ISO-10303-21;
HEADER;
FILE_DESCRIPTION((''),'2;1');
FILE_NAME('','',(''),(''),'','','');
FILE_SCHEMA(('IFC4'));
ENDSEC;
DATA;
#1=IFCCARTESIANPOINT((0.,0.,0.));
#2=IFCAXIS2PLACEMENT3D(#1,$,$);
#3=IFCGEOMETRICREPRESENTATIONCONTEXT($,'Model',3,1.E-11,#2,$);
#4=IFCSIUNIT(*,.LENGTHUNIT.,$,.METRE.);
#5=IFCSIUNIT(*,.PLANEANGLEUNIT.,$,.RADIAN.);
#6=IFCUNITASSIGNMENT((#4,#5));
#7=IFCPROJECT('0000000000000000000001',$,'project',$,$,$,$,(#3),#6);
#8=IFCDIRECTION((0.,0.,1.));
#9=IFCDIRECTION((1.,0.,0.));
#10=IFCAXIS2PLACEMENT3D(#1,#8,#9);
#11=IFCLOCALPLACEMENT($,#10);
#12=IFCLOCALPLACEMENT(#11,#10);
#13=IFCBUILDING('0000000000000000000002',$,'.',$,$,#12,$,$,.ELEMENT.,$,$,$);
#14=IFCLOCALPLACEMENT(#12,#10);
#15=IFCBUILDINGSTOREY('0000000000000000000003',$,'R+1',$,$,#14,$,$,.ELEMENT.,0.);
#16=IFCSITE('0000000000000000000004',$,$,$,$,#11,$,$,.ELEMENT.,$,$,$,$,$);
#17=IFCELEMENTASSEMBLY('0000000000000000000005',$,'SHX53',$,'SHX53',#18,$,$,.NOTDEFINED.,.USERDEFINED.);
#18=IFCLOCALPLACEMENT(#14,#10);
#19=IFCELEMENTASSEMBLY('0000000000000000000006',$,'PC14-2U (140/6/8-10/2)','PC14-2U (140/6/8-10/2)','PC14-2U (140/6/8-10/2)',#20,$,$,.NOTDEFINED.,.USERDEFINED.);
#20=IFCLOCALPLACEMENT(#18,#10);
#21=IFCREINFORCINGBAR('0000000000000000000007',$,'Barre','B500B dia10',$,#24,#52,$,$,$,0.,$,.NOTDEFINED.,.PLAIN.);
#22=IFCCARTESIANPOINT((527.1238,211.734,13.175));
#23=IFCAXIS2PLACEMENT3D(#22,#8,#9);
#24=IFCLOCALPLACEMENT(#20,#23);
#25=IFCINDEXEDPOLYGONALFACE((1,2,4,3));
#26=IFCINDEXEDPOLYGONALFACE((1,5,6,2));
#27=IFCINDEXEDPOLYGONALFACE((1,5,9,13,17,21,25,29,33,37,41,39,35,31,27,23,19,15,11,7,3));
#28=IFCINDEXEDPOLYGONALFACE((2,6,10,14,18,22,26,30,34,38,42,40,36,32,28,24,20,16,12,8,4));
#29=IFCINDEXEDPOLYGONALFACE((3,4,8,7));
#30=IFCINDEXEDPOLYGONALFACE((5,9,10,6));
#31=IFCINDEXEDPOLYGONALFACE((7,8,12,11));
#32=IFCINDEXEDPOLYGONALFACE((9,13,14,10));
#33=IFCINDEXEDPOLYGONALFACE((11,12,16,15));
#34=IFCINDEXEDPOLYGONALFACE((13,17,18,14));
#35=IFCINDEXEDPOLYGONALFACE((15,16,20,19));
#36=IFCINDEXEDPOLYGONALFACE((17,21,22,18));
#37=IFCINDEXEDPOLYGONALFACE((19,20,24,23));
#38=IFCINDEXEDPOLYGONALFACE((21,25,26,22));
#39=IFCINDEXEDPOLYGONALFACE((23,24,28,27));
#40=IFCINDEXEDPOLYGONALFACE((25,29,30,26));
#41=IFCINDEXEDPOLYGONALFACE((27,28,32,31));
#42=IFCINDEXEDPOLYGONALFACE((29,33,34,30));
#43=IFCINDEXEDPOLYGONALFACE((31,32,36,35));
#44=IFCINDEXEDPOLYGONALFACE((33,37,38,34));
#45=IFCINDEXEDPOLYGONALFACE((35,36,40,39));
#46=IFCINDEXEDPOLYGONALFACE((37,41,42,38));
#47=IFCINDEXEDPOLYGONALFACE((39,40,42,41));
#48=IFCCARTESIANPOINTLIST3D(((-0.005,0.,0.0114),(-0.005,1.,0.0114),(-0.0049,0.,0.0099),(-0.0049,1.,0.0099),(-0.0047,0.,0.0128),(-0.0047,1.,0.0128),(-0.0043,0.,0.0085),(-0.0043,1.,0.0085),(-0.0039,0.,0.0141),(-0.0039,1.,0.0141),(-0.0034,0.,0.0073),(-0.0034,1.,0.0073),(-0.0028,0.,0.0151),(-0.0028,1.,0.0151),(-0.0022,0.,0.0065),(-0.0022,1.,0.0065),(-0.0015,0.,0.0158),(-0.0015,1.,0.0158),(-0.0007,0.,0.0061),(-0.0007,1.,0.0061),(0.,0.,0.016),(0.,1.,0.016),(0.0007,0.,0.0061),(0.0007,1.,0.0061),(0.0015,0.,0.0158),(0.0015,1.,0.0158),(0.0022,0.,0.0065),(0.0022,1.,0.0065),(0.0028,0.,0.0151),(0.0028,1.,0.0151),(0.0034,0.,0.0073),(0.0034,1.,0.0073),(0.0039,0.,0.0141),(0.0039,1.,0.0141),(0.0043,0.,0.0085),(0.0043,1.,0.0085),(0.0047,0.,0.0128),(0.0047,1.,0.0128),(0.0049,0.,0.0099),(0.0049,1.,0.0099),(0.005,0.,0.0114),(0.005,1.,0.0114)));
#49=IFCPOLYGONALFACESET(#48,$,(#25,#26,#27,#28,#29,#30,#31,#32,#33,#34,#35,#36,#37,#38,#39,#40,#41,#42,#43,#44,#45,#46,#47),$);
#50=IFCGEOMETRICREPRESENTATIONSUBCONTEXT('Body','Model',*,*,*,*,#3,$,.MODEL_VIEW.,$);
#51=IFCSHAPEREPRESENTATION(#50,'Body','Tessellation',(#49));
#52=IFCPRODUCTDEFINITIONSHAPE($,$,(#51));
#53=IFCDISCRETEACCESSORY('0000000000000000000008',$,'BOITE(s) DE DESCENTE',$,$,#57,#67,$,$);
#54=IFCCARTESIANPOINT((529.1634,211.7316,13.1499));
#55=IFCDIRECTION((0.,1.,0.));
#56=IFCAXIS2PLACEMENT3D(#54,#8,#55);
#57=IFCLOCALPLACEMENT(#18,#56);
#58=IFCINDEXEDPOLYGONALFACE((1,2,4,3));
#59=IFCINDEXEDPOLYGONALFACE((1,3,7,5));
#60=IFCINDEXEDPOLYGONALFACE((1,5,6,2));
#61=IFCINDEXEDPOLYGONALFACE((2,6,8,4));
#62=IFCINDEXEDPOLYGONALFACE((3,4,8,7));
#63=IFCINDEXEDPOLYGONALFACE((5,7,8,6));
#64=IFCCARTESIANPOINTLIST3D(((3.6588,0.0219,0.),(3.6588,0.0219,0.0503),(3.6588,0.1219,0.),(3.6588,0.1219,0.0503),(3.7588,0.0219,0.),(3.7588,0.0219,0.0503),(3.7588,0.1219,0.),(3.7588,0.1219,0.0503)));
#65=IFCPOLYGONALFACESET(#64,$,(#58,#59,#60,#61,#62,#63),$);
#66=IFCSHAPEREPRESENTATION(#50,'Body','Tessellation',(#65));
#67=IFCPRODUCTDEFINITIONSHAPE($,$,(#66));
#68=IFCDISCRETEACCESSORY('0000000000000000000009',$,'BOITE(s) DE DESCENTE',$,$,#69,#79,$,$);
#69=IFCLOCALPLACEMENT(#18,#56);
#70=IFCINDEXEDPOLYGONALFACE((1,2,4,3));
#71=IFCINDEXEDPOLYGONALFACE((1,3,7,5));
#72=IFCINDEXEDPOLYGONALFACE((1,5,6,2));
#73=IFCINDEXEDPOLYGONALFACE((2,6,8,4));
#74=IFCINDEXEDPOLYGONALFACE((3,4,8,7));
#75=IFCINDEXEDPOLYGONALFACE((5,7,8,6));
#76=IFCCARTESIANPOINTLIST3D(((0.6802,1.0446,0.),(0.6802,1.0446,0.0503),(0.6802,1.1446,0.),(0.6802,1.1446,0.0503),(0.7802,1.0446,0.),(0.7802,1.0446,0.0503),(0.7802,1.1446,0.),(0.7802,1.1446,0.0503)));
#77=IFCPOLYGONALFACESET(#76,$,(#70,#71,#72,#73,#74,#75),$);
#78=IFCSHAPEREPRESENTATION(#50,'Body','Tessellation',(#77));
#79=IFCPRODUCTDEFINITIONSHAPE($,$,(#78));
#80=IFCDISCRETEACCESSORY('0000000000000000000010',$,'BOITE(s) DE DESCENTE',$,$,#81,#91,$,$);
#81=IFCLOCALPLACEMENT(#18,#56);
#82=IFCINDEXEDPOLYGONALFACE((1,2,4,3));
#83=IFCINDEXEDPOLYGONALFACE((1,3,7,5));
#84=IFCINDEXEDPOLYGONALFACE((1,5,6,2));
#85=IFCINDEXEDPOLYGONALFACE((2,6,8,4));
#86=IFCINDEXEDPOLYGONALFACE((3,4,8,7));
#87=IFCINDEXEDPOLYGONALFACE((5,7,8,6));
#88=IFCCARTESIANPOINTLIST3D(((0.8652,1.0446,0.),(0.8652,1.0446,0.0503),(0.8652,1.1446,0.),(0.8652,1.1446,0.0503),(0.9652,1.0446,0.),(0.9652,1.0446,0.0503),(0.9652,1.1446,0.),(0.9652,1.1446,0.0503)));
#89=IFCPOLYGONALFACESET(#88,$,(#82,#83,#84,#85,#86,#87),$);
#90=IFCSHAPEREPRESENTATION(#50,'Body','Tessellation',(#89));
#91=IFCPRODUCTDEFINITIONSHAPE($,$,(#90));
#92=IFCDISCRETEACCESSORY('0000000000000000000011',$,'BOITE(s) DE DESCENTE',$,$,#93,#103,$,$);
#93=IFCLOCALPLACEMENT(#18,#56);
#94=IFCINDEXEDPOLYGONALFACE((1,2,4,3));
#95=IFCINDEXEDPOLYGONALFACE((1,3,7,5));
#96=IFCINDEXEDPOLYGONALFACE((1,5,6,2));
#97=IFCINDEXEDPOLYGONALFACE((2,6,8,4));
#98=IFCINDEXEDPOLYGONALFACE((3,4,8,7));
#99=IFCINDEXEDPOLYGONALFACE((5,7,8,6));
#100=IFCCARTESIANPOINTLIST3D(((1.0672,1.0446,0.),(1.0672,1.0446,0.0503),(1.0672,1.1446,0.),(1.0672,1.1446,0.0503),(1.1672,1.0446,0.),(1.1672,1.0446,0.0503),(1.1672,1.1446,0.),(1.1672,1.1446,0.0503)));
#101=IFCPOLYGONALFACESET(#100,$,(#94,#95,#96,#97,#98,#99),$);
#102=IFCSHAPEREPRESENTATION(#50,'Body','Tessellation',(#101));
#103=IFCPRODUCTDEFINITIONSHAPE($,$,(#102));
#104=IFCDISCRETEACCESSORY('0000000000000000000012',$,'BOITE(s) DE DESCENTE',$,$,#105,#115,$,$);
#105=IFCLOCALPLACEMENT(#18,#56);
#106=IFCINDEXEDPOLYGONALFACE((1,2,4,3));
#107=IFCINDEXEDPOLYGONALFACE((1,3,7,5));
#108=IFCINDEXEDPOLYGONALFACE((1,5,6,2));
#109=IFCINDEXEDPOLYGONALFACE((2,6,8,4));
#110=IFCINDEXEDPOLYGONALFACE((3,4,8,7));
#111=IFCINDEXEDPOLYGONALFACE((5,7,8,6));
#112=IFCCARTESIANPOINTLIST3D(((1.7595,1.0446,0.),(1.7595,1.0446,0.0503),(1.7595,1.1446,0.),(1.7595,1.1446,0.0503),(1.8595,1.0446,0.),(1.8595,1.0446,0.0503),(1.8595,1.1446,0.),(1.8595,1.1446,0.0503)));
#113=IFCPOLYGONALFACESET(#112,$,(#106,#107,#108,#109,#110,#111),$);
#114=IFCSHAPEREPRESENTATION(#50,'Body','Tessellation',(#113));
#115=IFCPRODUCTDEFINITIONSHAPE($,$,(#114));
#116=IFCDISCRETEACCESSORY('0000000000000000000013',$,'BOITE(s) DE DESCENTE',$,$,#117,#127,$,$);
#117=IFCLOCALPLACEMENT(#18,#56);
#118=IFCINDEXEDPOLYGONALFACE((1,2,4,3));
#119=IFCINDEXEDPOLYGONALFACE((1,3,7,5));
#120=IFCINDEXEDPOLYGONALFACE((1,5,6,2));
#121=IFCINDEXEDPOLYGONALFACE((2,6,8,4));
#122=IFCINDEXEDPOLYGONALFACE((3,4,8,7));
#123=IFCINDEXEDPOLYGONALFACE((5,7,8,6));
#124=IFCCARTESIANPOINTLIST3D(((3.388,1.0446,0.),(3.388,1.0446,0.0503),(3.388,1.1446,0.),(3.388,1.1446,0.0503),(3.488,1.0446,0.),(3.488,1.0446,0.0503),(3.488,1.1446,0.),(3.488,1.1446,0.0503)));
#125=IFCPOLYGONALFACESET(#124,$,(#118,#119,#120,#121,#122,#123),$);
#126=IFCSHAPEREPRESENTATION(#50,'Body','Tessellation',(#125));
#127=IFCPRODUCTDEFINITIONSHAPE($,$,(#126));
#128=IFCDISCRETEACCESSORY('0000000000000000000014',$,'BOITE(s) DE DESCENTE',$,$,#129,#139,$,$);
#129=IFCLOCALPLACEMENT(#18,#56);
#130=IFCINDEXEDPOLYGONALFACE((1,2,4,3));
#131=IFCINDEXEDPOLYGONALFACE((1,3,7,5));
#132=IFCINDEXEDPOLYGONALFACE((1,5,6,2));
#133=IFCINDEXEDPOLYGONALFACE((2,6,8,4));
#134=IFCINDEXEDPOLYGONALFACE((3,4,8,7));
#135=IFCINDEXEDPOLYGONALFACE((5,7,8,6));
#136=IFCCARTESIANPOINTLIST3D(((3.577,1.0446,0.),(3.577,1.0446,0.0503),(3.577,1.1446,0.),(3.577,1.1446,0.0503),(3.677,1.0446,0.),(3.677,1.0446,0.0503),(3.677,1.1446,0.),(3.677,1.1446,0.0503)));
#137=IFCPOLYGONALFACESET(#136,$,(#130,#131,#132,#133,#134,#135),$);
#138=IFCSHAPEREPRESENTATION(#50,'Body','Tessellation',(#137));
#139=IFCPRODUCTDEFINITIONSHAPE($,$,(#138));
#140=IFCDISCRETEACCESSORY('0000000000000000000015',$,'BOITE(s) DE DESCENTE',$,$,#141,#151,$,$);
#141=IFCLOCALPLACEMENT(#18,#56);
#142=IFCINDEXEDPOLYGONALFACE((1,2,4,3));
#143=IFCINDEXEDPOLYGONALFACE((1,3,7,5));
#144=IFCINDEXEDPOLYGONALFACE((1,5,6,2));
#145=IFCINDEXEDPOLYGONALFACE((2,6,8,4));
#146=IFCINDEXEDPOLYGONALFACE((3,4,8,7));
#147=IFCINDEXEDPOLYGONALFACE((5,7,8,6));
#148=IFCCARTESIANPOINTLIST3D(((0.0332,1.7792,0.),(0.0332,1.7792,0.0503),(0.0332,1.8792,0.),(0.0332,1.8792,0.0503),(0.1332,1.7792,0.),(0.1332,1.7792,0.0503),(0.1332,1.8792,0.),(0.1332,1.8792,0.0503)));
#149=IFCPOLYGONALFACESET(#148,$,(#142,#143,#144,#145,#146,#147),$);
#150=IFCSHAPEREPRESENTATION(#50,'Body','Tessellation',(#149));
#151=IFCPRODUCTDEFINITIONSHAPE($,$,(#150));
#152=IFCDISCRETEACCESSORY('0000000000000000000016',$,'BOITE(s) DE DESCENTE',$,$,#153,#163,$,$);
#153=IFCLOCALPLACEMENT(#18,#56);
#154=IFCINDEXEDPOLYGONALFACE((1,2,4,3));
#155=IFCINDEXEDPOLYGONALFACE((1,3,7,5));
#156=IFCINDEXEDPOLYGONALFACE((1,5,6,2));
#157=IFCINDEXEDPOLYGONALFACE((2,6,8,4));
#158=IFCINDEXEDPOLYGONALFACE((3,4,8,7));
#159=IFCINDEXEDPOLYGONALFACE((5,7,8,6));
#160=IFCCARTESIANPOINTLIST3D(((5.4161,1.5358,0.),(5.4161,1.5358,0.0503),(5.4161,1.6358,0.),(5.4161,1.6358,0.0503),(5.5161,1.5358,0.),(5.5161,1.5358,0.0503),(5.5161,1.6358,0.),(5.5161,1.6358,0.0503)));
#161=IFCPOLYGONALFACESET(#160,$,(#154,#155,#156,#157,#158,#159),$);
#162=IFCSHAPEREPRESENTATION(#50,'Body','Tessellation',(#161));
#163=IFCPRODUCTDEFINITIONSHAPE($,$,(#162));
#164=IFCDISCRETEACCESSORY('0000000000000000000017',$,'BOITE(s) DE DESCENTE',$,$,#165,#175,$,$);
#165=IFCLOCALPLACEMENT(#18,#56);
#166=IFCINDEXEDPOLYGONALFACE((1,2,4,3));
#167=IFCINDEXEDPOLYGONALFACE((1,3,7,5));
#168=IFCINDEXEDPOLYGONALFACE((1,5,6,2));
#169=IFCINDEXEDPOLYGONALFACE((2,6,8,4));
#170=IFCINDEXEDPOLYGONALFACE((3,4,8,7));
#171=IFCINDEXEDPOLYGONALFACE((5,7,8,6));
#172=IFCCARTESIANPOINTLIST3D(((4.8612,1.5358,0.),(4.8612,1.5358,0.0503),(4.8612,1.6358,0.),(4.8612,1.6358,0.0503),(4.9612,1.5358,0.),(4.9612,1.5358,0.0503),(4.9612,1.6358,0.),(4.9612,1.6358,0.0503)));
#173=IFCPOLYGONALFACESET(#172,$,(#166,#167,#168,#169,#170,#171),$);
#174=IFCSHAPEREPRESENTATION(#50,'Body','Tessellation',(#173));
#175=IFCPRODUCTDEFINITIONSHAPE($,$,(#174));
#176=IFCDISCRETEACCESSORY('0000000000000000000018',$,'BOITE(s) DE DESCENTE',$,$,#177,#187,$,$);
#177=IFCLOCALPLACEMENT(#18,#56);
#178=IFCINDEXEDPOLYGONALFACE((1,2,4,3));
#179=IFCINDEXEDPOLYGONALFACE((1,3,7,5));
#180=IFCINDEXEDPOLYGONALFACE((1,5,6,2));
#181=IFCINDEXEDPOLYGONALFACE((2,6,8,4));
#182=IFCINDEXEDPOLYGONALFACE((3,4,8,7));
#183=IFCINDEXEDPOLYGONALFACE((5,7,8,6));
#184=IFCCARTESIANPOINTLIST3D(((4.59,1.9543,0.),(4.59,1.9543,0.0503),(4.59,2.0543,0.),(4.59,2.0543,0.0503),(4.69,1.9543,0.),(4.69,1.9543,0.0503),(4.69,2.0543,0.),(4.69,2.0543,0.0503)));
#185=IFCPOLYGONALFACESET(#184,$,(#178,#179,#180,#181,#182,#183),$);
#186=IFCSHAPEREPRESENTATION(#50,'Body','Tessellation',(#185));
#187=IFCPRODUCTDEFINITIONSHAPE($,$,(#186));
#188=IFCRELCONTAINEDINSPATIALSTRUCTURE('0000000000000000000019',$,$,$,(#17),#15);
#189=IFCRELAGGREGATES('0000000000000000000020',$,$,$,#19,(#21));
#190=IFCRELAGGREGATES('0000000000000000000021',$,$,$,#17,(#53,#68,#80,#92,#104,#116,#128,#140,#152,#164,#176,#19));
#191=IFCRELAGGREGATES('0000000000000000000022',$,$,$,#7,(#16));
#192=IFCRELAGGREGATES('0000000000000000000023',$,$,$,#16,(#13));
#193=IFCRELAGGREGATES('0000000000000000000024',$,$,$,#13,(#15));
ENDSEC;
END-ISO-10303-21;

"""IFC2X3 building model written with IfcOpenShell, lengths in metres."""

from ifc_helpers import new_model, entity, si_unit, frame, origin, origin_with_axes, place, context, subcontext, project, spatial, polyline, outline, extrude, source, transform, mapped, element, aggregate, save


model = new_model("IFC2X3")

# Units and contexts
model_context = context("Model", 3, precision=1e-11, world=origin())
body_context = subcontext(model_context, "Body", "Model", "MODEL_VIEW")
ifc_project = project(units=[si_unit("LENGTHUNIT", "METRE"), si_unit("PLANEANGLEUNIT", "RADIAN")], contexts=[model_context])

# Site, building, storey
site_placement = place(None, origin_with_axes())
site = spatial("IfcSite", under=ifc_project, at=site_placement, CompositionType="ELEMENT")
building_placement = place(site_placement, origin_with_axes())
building = spatial("IfcBuilding", under=site, at=building_placement, Name=".", CompositionType="ELEMENT")
storey_placement = place(building_placement, origin_with_axes())
storey = spatial("IfcBuildingStorey", under=building, at=storey_placement, Name="R+1", CompositionType="ELEMENT", Elevation=0.0)

# Element assemblies, reinforcing bar, discrete accessories
assembly_1_placement = place(storey_placement, origin_with_axes())
assembly_1 = element("IfcElementAssembly", 1, at=assembly_1_placement, inside=storey, Name="SHX53", ObjectType="SHX53", AssemblyPlace="NOTDEFINED", PredefinedType="USERDEFINED")
assembly_2_placement = place(assembly_1_placement, origin_with_axes())
assembly_2 = element("IfcElementAssembly", 2, at=assembly_2_placement, Name="PC14-2U (140/6/8-10/2)", Description="PC14-2U (140/6/8-10/2)", ObjectType="PC14-2U (140/6/8-10/2)", AssemblyPlace="NOTDEFINED", PredefinedType="USERDEFINED")
shared_shape_1 = source(origin_with_axes(), body_context, "Body", "AdvancedSweptSolid", [
    entity("IfcSweptDiskSolid", entity("IfcPolyline", [entity("IfcCartesianPoint", [0.0, 0.0, 0.011]), entity("IfcCartesianPoint", [0.0, 1.0, 0.011])]), 0.005, None, 0.0, 1.0),
])
reinforcing_bar_1_placement = place(assembly_2_placement, frame((527.1238, 211.734, 13.175), z_axis=(0.0, 0.0, 1.0), x_axis=(1.0, 0.0, 0.0)))
reinforcing_bar_1 = element("IfcReinforcingBar", 3, at=reinforcing_bar_1_placement, Name="Barre", Description="B500B dia10", BarRole="NOTDEFINED", BarSurface="PLAIN", CrossSectionArea=0.0, context=body_context, shape_type="MappedRepresentation", body=[
    mapped(shared_shape_1, transform((0.0, 0.0, 0.0), scale=1.0)),
])
aggregate(assembly_2, [reinforcing_bar_1])
discrete_accessory_1_placement = place(assembly_1_placement, frame((529.1634, 211.7316, 13.1499), z_axis=(0.0, 0.0, 1.0), x_axis=(0.0, 1.0, 0.0)))
discrete_accessory_1 = element("IfcDiscreteAccessory", 4, at=discrete_accessory_1_placement, Name="BOITE(s) DE DESCENTE", context=body_context, shape_type="SweptSolid", body=[
    extrude(outline(polyline([(0.0219, -3.6588), (0.0219, -3.7588), (0.1219, -3.7588), (0.1219, -3.6588), (0.0219, -3.6588)])), frame((0.0, 0.0, 0.0), z_axis=(0.0, 0.0, 1.0), x_axis=(0.0, 1.0, 0.0)), (0.0, 0.0, 1.0), 0.0503),
])
discrete_accessory_2_placement = place(assembly_1_placement, frame((529.1634, 211.7316, 13.1499), z_axis=(0.0, 0.0, 1.0), x_axis=(0.0, 1.0, 0.0)))
discrete_accessory_2 = element("IfcDiscreteAccessory", 5, at=discrete_accessory_2_placement, Name="BOITE(s) DE DESCENTE", context=body_context, shape_type="SweptSolid", body=[
    extrude(outline(polyline([(1.0446, -0.6802), (1.0446, -0.7802), (1.1446, -0.7802), (1.1446, -0.6802), (1.0446, -0.6802)])), frame((0.0, 0.0, 0.0), z_axis=(0.0, 0.0, 1.0), x_axis=(0.0, 1.0, 0.0)), (0.0, 0.0, 1.0), 0.0503),
])
discrete_accessory_3_placement = place(assembly_1_placement, frame((529.1634, 211.7316, 13.1499), z_axis=(0.0, 0.0, 1.0), x_axis=(0.0, 1.0, 0.0)))
discrete_accessory_3 = element("IfcDiscreteAccessory", 6, at=discrete_accessory_3_placement, Name="BOITE(s) DE DESCENTE", context=body_context, shape_type="SweptSolid", body=[
    extrude(outline(polyline([(1.0446, -0.8652), (1.0446, -0.9652), (1.1446, -0.9652), (1.1446, -0.8652), (1.0446, -0.8652)])), frame((0.0, 0.0, 0.0), z_axis=(0.0, 0.0, 1.0), x_axis=(0.0, 1.0, 0.0)), (0.0, 0.0, 1.0), 0.0503),
])
discrete_accessory_4_placement = place(assembly_1_placement, frame((529.1634, 211.7316, 13.1499), z_axis=(0.0, 0.0, 1.0), x_axis=(0.0, 1.0, 0.0)))
discrete_accessory_4 = element("IfcDiscreteAccessory", 7, at=discrete_accessory_4_placement, Name="BOITE(s) DE DESCENTE", context=body_context, shape_type="SweptSolid", body=[
    extrude(outline(polyline([(1.0446, -1.0672), (1.0446, -1.1672), (1.1446, -1.1672), (1.1446, -1.0672), (1.0446, -1.0672)])), frame((0.0, 0.0, 0.0), z_axis=(0.0, 0.0, 1.0), x_axis=(0.0, 1.0, 0.0)), (0.0, 0.0, 1.0), 0.0503),
])
discrete_accessory_5_placement = place(assembly_1_placement, frame((529.1634, 211.7316, 13.1499), z_axis=(0.0, 0.0, 1.0), x_axis=(0.0, 1.0, 0.0)))
discrete_accessory_5 = element("IfcDiscreteAccessory", 8, at=discrete_accessory_5_placement, Name="BOITE(s) DE DESCENTE", context=body_context, shape_type="SweptSolid", body=[
    extrude(outline(polyline([(1.0446, -1.7595), (1.0446, -1.8595), (1.1446, -1.8595), (1.1446, -1.7595), (1.0446, -1.7595)])), frame((0.0, 0.0, 0.0), z_axis=(0.0, 0.0, 1.0), x_axis=(0.0, 1.0, 0.0)), (0.0, 0.0, 1.0), 0.0503),
])
discrete_accessory_6_placement = place(assembly_1_placement, frame((529.1634, 211.7316, 13.1499), z_axis=(0.0, 0.0, 1.0), x_axis=(0.0, 1.0, 0.0)))
discrete_accessory_6 = element("IfcDiscreteAccessory", 9, at=discrete_accessory_6_placement, Name="BOITE(s) DE DESCENTE", context=body_context, shape_type="SweptSolid", body=[
    extrude(outline(polyline([(1.0446, -3.388), (1.0446, -3.488), (1.1446, -3.488), (1.1446, -3.388), (1.0446, -3.388)])), frame((0.0, 0.0, 0.0), z_axis=(0.0, 0.0, 1.0), x_axis=(0.0, 1.0, 0.0)), (0.0, 0.0, 1.0), 0.0503),
])
discrete_accessory_7_placement = place(assembly_1_placement, frame((529.1634, 211.7316, 13.1499), z_axis=(0.0, 0.0, 1.0), x_axis=(0.0, 1.0, 0.0)))
discrete_accessory_7 = element("IfcDiscreteAccessory", 10, at=discrete_accessory_7_placement, Name="BOITE(s) DE DESCENTE", context=body_context, shape_type="SweptSolid", body=[
    extrude(outline(polyline([(1.0446, -3.577), (1.0446, -3.677), (1.1446, -3.677), (1.1446, -3.577), (1.0446, -3.577)])), frame((0.0, 0.0, 0.0), z_axis=(0.0, 0.0, 1.0), x_axis=(0.0, 1.0, 0.0)), (0.0, 0.0, 1.0), 0.0503),
])
discrete_accessory_8_placement = place(assembly_1_placement, frame((529.1634, 211.7316, 13.1499), z_axis=(0.0, 0.0, 1.0), x_axis=(0.0, 1.0, 0.0)))
discrete_accessory_8 = element("IfcDiscreteAccessory", 11, at=discrete_accessory_8_placement, Name="BOITE(s) DE DESCENTE", context=body_context, shape_type="SweptSolid", body=[
    extrude(outline(polyline([(1.7792, -0.0332), (1.7792, -0.1332), (1.8792, -0.1332), (1.8792, -0.0332), (1.7792, -0.0332)])), frame((0.0, 0.0, 0.0), z_axis=(0.0, 0.0, 1.0), x_axis=(0.0, 1.0, 0.0)), (0.0, 0.0, 1.0), 0.0503),
])
discrete_accessory_9_placement = place(assembly_1_placement, frame((529.1634, 211.7316, 13.1499), z_axis=(0.0, 0.0, 1.0), x_axis=(0.0, 1.0, 0.0)))
discrete_accessory_9 = element("IfcDiscreteAccessory", 12, at=discrete_accessory_9_placement, Name="BOITE(s) DE DESCENTE", context=body_context, shape_type="SweptSolid", body=[
    extrude(outline(polyline([(1.5358, -5.4161), (1.5358, -5.5161), (1.6358, -5.5161), (1.6358, -5.4161), (1.5358, -5.4161)])), frame((0.0, 0.0, 0.0), z_axis=(0.0, 0.0, 1.0), x_axis=(0.0, 1.0, 0.0)), (0.0, 0.0, 1.0), 0.0503),
])
discrete_accessory_10_placement = place(assembly_1_placement, frame((529.1634, 211.7316, 13.1499), z_axis=(0.0, 0.0, 1.0), x_axis=(0.0, 1.0, 0.0)))
discrete_accessory_10 = element("IfcDiscreteAccessory", 13, at=discrete_accessory_10_placement, Name="BOITE(s) DE DESCENTE", context=body_context, shape_type="SweptSolid", body=[
    extrude(outline(polyline([(1.5358, -4.8612), (1.5358, -4.9612), (1.6358, -4.9612), (1.6358, -4.8612), (1.5358, -4.8612)])), frame((0.0, 0.0, 0.0), z_axis=(0.0, 0.0, 1.0), x_axis=(0.0, 1.0, 0.0)), (0.0, 0.0, 1.0), 0.0503),
])
discrete_accessory_11_placement = place(assembly_1_placement, frame((529.1634, 211.7316, 13.1499), z_axis=(0.0, 0.0, 1.0), x_axis=(0.0, 1.0, 0.0)))
discrete_accessory_11 = element("IfcDiscreteAccessory", 14, at=discrete_accessory_11_placement, Name="BOITE(s) DE DESCENTE", context=body_context, shape_type="SweptSolid", body=[
    extrude(outline(polyline([(1.9543, -4.59), (1.9543, -4.69), (2.0543, -4.69), (2.0543, -4.59), (1.9543, -4.59)])), frame((0.0, 0.0, 0.0), z_axis=(0.0, 0.0, 1.0), x_axis=(0.0, 1.0, 0.0)), (0.0, 0.0, 1.0), 0.0503),
])
aggregate(assembly_1, [discrete_accessory_1, discrete_accessory_2, discrete_accessory_3, discrete_accessory_4, discrete_accessory_5, discrete_accessory_6, discrete_accessory_7, discrete_accessory_8, discrete_accessory_9, discrete_accessory_10, discrete_accessory_11, assembly_2])

save(model, "model.ifc")
